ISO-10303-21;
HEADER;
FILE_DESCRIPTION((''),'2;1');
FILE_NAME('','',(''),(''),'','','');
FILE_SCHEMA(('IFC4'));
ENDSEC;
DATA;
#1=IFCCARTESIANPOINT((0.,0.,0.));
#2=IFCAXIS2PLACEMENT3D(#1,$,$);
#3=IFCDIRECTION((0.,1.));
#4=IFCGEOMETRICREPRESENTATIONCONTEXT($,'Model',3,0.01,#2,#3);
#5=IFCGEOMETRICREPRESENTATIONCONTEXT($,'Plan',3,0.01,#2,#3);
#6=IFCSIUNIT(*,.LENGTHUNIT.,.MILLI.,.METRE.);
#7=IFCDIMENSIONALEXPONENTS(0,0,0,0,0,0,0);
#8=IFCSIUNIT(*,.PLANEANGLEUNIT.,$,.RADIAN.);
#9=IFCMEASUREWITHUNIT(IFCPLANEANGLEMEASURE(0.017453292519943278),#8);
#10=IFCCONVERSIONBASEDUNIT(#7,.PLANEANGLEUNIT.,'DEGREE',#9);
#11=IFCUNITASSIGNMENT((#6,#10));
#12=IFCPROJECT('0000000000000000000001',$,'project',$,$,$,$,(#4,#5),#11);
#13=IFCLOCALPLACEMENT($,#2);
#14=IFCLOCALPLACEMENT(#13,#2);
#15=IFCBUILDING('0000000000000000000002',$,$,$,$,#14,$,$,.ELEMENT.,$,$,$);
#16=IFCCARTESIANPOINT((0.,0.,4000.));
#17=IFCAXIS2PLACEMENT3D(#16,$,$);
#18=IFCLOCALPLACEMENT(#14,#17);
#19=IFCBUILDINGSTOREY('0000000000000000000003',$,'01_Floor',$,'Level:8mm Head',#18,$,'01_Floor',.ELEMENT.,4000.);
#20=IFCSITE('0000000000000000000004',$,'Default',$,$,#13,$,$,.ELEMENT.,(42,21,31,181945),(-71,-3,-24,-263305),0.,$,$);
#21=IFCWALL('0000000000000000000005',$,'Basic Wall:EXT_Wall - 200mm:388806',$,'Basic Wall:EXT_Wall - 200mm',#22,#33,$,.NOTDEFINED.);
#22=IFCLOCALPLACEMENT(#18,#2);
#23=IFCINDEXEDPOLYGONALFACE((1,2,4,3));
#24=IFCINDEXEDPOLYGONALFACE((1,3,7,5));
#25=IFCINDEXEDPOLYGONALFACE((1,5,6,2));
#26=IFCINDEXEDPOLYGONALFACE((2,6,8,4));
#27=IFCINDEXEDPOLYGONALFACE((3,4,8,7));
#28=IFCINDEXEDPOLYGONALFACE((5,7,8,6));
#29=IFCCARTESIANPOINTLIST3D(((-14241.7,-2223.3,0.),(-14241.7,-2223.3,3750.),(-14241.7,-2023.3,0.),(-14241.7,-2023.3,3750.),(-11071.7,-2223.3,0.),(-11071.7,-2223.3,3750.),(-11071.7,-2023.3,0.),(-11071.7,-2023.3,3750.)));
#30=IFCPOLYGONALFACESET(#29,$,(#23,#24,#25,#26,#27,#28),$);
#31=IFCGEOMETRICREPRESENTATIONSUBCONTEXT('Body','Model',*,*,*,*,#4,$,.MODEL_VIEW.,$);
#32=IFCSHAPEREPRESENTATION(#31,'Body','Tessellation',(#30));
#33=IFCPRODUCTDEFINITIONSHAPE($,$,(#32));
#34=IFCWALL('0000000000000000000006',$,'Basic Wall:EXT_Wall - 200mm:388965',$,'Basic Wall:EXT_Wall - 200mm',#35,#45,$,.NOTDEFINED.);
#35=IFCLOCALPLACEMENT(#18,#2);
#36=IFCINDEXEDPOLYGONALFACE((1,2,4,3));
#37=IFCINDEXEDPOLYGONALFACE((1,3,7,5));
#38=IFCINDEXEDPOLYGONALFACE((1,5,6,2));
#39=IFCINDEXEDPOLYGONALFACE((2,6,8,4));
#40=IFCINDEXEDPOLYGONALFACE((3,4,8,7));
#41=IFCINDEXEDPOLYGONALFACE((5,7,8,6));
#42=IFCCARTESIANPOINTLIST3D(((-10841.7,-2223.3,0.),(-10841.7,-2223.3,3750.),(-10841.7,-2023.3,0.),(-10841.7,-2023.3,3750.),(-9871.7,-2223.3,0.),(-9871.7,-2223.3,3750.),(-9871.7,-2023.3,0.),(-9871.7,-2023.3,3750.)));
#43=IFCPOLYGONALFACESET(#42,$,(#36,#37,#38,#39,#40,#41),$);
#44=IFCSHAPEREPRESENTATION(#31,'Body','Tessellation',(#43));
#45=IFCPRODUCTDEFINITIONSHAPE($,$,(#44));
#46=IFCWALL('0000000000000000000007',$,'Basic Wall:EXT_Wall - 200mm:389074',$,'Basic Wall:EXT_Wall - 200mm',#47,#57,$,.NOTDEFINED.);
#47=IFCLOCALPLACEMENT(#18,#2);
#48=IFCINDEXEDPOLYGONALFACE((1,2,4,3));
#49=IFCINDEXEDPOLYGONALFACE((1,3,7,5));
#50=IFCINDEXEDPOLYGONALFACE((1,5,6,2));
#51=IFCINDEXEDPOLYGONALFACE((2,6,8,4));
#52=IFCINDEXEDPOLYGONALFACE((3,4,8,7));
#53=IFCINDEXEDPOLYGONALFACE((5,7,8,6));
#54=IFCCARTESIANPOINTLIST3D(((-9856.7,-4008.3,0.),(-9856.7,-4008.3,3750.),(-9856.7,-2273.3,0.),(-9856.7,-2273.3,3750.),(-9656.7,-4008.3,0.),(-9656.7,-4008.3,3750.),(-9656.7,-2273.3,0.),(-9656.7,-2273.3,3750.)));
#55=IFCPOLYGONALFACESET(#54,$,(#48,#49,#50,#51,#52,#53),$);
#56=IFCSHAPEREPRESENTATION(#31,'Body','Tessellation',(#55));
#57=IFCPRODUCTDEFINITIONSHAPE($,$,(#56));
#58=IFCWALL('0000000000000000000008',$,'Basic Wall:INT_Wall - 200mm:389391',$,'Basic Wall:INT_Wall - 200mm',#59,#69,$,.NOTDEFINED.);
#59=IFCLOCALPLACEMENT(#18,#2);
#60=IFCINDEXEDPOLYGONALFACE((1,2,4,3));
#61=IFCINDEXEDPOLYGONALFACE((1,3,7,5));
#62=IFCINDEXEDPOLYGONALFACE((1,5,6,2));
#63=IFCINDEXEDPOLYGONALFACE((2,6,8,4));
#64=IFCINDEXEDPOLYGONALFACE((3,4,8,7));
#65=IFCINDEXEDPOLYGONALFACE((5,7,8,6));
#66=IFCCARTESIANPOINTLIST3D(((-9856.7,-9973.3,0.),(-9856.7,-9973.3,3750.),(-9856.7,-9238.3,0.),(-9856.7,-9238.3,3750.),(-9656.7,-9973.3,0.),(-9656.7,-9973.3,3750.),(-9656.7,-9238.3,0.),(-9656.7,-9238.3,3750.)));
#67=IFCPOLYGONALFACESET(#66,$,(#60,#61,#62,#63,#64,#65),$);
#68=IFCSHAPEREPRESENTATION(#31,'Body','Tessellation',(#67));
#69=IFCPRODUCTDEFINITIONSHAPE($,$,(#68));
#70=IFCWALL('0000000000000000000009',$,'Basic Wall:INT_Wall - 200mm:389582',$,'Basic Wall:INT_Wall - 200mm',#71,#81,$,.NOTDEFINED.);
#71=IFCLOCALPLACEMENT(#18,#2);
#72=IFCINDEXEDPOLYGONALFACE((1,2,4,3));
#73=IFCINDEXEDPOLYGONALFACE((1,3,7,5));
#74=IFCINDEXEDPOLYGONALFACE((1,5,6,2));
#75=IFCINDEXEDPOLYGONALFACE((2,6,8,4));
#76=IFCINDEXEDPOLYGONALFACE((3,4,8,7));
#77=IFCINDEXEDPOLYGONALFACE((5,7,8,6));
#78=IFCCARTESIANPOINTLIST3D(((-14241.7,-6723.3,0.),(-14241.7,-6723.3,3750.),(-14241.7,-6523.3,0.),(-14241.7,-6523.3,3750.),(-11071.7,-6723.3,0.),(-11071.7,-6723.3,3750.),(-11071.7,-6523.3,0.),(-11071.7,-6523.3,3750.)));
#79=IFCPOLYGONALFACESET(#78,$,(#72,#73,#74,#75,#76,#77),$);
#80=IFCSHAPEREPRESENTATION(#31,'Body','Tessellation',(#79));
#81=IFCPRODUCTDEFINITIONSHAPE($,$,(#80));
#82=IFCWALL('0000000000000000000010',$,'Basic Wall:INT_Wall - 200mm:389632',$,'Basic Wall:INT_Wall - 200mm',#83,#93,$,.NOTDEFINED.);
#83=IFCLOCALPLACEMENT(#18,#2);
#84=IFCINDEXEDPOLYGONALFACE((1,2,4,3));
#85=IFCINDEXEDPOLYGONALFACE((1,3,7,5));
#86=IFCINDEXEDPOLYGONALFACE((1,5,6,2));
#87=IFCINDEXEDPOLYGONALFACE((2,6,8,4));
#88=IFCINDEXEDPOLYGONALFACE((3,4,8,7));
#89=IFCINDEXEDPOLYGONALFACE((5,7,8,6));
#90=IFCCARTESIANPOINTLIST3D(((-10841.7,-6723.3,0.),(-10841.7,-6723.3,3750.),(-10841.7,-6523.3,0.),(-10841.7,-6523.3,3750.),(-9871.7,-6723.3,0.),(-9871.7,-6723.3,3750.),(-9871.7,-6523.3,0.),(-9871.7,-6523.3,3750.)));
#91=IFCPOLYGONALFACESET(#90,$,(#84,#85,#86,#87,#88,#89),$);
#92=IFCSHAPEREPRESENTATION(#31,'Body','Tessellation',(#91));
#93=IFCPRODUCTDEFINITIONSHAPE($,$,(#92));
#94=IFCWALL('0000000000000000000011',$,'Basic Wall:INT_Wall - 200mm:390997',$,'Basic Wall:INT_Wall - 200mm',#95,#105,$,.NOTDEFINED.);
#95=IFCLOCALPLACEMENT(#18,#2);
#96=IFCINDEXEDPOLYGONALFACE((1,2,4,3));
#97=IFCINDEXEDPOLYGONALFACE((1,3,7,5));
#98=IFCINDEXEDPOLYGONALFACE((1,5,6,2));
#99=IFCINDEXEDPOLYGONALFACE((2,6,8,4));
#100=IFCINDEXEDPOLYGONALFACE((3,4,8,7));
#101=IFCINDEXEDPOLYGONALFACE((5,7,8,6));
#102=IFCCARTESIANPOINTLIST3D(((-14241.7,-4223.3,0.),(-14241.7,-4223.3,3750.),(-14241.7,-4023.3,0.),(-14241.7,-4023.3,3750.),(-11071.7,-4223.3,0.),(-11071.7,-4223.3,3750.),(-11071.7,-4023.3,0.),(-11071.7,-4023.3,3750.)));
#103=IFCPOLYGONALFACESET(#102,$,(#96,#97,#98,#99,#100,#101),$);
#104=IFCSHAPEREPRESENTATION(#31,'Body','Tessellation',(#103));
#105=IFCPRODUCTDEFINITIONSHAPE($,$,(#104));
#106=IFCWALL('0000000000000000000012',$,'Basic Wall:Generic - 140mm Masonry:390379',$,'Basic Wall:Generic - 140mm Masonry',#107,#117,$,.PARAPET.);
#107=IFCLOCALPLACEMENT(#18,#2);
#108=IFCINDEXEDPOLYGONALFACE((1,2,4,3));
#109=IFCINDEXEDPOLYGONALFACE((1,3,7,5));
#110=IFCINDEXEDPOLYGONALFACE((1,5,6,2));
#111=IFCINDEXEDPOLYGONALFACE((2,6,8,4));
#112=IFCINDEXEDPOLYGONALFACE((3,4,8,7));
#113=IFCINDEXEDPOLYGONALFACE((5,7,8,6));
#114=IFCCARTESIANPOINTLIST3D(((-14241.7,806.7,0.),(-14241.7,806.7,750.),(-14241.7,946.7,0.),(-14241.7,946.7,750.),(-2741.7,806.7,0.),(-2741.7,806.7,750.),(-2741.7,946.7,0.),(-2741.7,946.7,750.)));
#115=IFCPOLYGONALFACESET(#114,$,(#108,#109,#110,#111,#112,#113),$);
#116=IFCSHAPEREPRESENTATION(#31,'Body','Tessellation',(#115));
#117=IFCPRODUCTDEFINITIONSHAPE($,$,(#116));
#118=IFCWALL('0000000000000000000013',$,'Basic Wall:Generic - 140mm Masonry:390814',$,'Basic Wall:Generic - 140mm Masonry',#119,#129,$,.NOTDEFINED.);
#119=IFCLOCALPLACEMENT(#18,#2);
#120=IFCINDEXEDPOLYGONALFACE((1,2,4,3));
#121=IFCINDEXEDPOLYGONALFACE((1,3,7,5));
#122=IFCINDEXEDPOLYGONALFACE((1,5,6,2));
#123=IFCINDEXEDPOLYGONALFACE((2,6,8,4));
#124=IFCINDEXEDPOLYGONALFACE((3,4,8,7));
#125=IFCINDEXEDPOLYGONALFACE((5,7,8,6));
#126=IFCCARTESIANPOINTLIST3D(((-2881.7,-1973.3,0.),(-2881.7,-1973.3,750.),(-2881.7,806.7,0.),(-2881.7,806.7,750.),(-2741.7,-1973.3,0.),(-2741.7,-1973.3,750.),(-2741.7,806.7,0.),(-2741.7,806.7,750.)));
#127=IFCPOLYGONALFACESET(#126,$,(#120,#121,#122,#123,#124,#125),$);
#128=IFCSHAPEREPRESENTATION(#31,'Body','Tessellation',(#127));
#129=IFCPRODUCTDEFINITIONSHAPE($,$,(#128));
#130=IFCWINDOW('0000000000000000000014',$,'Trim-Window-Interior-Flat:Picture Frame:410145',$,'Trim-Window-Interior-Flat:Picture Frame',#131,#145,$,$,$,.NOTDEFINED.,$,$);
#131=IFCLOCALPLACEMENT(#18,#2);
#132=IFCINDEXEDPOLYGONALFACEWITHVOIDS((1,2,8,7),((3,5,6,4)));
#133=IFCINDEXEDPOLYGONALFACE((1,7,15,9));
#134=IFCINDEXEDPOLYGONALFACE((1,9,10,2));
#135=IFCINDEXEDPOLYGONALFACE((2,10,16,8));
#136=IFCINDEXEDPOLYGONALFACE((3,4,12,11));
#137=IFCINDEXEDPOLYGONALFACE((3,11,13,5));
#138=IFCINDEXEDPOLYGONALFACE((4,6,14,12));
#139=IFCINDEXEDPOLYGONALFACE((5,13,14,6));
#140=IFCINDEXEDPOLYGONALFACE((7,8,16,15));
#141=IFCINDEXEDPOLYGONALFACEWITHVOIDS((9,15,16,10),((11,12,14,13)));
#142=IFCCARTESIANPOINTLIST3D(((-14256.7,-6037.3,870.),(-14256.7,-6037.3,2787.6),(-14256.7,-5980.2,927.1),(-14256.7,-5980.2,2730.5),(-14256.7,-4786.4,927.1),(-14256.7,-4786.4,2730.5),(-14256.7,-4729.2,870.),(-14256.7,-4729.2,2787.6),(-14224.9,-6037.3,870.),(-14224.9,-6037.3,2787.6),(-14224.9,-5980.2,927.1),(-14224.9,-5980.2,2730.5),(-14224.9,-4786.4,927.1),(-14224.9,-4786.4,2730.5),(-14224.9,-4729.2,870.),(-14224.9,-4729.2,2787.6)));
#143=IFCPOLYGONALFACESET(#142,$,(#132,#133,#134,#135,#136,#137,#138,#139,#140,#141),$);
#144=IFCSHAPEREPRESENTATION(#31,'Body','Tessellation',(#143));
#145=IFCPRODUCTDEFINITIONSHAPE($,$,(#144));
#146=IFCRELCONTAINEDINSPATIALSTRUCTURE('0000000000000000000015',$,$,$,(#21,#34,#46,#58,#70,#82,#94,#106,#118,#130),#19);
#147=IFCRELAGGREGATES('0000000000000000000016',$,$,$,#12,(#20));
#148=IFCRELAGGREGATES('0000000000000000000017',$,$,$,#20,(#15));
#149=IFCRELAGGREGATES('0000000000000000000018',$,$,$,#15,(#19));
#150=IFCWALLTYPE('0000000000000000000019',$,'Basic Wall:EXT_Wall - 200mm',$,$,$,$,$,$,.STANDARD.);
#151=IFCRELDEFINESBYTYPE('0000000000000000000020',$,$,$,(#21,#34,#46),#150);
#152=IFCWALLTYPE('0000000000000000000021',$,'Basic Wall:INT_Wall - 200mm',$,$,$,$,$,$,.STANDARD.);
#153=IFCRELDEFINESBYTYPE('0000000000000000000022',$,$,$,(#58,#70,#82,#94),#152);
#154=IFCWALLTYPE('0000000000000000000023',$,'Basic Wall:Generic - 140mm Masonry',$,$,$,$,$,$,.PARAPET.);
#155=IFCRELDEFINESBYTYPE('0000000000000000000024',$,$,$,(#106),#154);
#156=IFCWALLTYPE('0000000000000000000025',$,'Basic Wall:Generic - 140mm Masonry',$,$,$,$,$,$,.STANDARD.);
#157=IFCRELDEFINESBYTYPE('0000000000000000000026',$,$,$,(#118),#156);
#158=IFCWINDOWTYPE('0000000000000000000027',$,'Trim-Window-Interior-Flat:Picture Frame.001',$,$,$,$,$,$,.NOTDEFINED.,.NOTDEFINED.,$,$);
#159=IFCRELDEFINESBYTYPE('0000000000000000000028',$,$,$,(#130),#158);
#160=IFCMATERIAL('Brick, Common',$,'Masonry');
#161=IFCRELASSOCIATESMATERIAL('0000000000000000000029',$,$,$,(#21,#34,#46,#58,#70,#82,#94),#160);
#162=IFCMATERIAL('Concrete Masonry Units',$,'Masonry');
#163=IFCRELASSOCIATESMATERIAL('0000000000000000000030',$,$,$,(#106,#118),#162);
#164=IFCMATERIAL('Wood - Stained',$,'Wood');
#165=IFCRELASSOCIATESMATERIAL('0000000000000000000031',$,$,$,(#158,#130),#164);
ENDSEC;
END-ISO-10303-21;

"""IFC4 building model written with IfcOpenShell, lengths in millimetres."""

from ifc_helpers import new_model, entity, si_unit, converted_unit, direction, frame, origin, place, context, subcontext, project, spatial, indexed_curve, outline, extrude, source, transform, mapped, material, type_object, type_shapes, element, save


model = new_model("IFC4")

# Units and contexts
model_context = context("Model", 3, precision=0.01, world=origin(), true_north=direction((0.0, 1.0)))
plan_context = context("Plan", 3, precision=0.01, world=origin(), true_north=direction((0.0, 1.0)))
body_context = subcontext(model_context, "Body", "Model", "MODEL_VIEW")
ifc_project = project(units=[si_unit("LENGTHUNIT", "METRE", prefix="MILLI"), converted_unit("PLANEANGLEUNIT", "DEGREE", entity("IfcPlaneAngleMeasure", 0.017453292519943278), si_unit("PLANEANGLEUNIT", "RADIAN"), dimensions=[0, 0, 0, 0, 0, 0, 0])], contexts=[model_context, plan_context])

# Site, building, storey
site_placement = place(None, origin())
site = spatial("IfcSite", under=ifc_project, at=site_placement, Name="Default", CompositionType="ELEMENT", RefLatitude=(42, 21, 31, 181945), RefLongitude=(-71, -3, -24, -263305), RefElevation=0.0)
building_placement = place(site_placement, origin())
building = spatial("IfcBuilding", under=site, at=building_placement, CompositionType="ELEMENT")
storey_placement = place(building_placement, frame((0.0, 0.0, 4000.0)))
storey = spatial("IfcBuildingStorey", under=building, at=storey_placement, Name="01_Floor", ObjectType="Level:8mm Head", LongName="01_Floor", CompositionType="ELEMENT", Elevation=4000.0)

# Walls
ifc_material_1 = material(Name="Brick, Common", Category="Masonry")
wall_type_1 = type_object("IfcWallType", Name="Basic Wall:EXT_Wall - 200mm", PredefinedType="STANDARD")
wall_1_placement = place(storey_placement, frame((-14241.7, -2123.3, 0.0)))
element("IfcWall", 1, at=wall_1_placement, inside=storey, type_object=wall_type_1, material=ifc_material_1, Name="Basic Wall:EXT_Wall - 200mm:388806", ObjectType="Basic Wall:EXT_Wall - 200mm", PredefinedType="NOTDEFINED", context=body_context, shape_type="SweptSolid", body=[
    extrude(outline(indexed_curve([(3170.0, 100.0), (0.0, 100.0), (0.0, -100.0), (3170.0, -100.0), (3170.0, 100.0)], self_intersect=False)), origin(), (0.0, 0.0, 1.0), 3750.0),
])
wall_2_placement = place(storey_placement, frame((-10841.7, -2123.3, 0.0)))
element("IfcWall", 2, at=wall_2_placement, inside=storey, type_object=wall_type_1, material=ifc_material_1, Name="Basic Wall:EXT_Wall - 200mm:388965", ObjectType="Basic Wall:EXT_Wall - 200mm", PredefinedType="NOTDEFINED", context=body_context, shape_type="SweptSolid", body=[
    extrude(outline(indexed_curve([(970.0, 100.0), (0.0, 100.0), (0.0, -100.0), (970.0, -100.0), (970.0, 100.0)], self_intersect=False)), origin(), (0.0, 0.0, 1.0), 3750.0),
])
wall_3_placement = place(storey_placement, frame((-9756.7, -2273.3, 0.0), z_axis=(0.0, 0.0, 1.0), x_axis=(0.0, -1.0, 0.0)))
element("IfcWall", 3, at=wall_3_placement, inside=storey, type_object=wall_type_1, material=ifc_material_1, Name="Basic Wall:EXT_Wall - 200mm:389074", ObjectType="Basic Wall:EXT_Wall - 200mm", PredefinedType="NOTDEFINED", context=body_context, shape_type="SweptSolid", body=[
    extrude(outline(indexed_curve([(1735.0, 100.0), (0.0, 100.0), (0.0, -100.0), (1735.0, -100.0), (1735.0, 100.0)], self_intersect=False)), origin(), (0.0, 0.0, 1.0), 3750.0),
])
wall_type_2 = type_object("IfcWallType", Name="Basic Wall:INT_Wall - 200mm", PredefinedType="STANDARD")
wall_4_placement = place(storey_placement, frame((-9756.7, -9973.3, 0.0), z_axis=(0.0, 0.0, 1.0), x_axis=(0.0, 1.0, 0.0)))
element("IfcWall", 4, at=wall_4_placement, inside=storey, type_object=wall_type_2, material=ifc_material_1, Name="Basic Wall:INT_Wall - 200mm:389391", ObjectType="Basic Wall:INT_Wall - 200mm", PredefinedType="NOTDEFINED", context=body_context, shape_type="SweptSolid", body=[
    extrude(outline(indexed_curve([(735.0, 100.0), (0.0, 100.0), (0.0, -100.0), (735.0, -100.0), (735.0, 100.0)], self_intersect=False)), origin(), (0.0, 0.0, 1.0), 3750.0),
])
wall_5_placement = place(storey_placement, frame((-14241.7, -6623.3, 0.0)))
element("IfcWall", 5, at=wall_5_placement, inside=storey, type_object=wall_type_2, material=ifc_material_1, Name="Basic Wall:INT_Wall - 200mm:389582", ObjectType="Basic Wall:INT_Wall - 200mm", PredefinedType="NOTDEFINED", context=body_context, shape_type="SweptSolid", body=[
    extrude(outline(indexed_curve([(3170.0, 100.0), (0.0, 100.0), (0.0, -100.0), (3170.0, -100.0), (3170.0, 100.0)], self_intersect=False)), origin(), (0.0, 0.0, 1.0), 3750.0),
])
wall_6_placement = place(storey_placement, frame((-10841.7, -6623.3, 0.0)))
element("IfcWall", 6, at=wall_6_placement, inside=storey, type_object=wall_type_2, material=ifc_material_1, Name="Basic Wall:INT_Wall - 200mm:389632", ObjectType="Basic Wall:INT_Wall - 200mm", PredefinedType="NOTDEFINED", context=body_context, shape_type="SweptSolid", body=[
    extrude(outline(indexed_curve([(970.0, 100.0), (0.0, 100.0), (0.0, -100.0), (970.0, -100.0), (970.0, 100.0)], self_intersect=False)), origin(), (0.0, 0.0, 1.0), 3750.0),
])
wall_7_placement = place(storey_placement, frame((-14241.7, -4123.3, 0.0)))
element("IfcWall", 7, at=wall_7_placement, inside=storey, type_object=wall_type_2, material=ifc_material_1, Name="Basic Wall:INT_Wall - 200mm:390997", ObjectType="Basic Wall:INT_Wall - 200mm", PredefinedType="NOTDEFINED", context=body_context, shape_type="SweptSolid", body=[
    extrude(outline(indexed_curve([(3170.0, 100.0), (0.0, 100.0), (0.0, -100.0), (3170.0, -100.0), (3170.0, 100.0)], self_intersect=False)), origin(), (0.0, 0.0, 1.0), 3750.0),
])
ifc_material_2 = material(Name="Concrete Masonry Units", Category="Masonry")
wall_type_3 = type_object("IfcWallType", Name="Basic Wall:Generic - 140mm Masonry", PredefinedType="PARAPET")
wall_8_placement = place(storey_placement, frame((-14241.7, 876.7, 0.0)))
element("IfcWall", 8, at=wall_8_placement, inside=storey, type_object=wall_type_3, material=ifc_material_2, Name="Basic Wall:Generic - 140mm Masonry:390379", ObjectType="Basic Wall:Generic - 140mm Masonry", PredefinedType="PARAPET", context=body_context, shape_type="SweptSolid", body=[
    extrude(outline(indexed_curve([(11500.0, 70.0), (0.0, 70.0), (0.0, -70.0), (11500.0, -70.0), (11500.0, 70.0)], self_intersect=False)), origin(), (0.0, 0.0, 1.0), 750.0),
])
wall_type_4 = type_object("IfcWallType", Name="Basic Wall:Generic - 140mm Masonry", PredefinedType="STANDARD")
wall_9_placement = place(storey_placement, frame((-2811.7, -1973.3, 0.0), z_axis=(0.0, 0.0, 1.0), x_axis=(0.0, 1.0, 0.0)))
element("IfcWall", 9, at=wall_9_placement, inside=storey, type_object=wall_type_4, material=ifc_material_2, Name="Basic Wall:Generic - 140mm Masonry:390814", ObjectType="Basic Wall:Generic - 140mm Masonry", PredefinedType="NOTDEFINED", context=body_context, shape_type="SweptSolid", body=[
    extrude(outline(indexed_curve([(2780.0, 70.0), (0.0, 70.0), (0.0, -70.0), (2780.0, -70.0), (2780.0, 70.0)], self_intersect=False)), origin(), (0.0, 0.0, 1.0), 750.0),
])

# Window
ifc_material_3 = material(Name="Wood - Stained", Category="Wood")
window_type = type_object("IfcWindowType", Name="Trim-Window-Interior-Flat:Picture Frame.001", PredefinedType="NOTDEFINED", material=ifc_material_3)
shared_shape_1 = source(origin(), body_context, "Body", "SweptSolid", [
    extrude(outline(indexed_curve([(-654.0, -958.8), (654.0, -958.8), (654.0, 958.8), (-654.0, 958.8), (-654.0, -958.8)], self_intersect=False), holes=[indexed_curve([(-596.9, -901.7), (-596.9, 901.7), (596.9, 901.7), (596.9, -901.7), (-596.9, -901.7)], self_intersect=False)]), frame((0.0, -914.4, 0.0), z_axis=(0.0, 0.0, 1.0), x_axis=(-1.0, 0.0, 0.0)), (0.0, 0.0, 1.0), 31.7),
])
type_shapes(window_type, [shared_shape_1])
window_placement = place(storey_placement, frame((-14256.7, -5383.3, 2743.2), z_axis=(1.0, 0.0, 0.0), x_axis=(0.0, 1.0, 0.0)))
element("IfcWindow", 10, at=window_placement, inside=storey, type_object=window_type, material=ifc_material_3, Name="Trim-Window-Interior-Flat:Picture Frame:410145", ObjectType="Trim-Window-Interior-Flat:Picture Frame", PredefinedType="NOTDEFINED", context=body_context, shape_type="MappedRepresentation", body=[
    mapped(shared_shape_1, transform((0.0, 0.0, 0.0), scale=1.0)),
])

save(model, "model.ifc")
